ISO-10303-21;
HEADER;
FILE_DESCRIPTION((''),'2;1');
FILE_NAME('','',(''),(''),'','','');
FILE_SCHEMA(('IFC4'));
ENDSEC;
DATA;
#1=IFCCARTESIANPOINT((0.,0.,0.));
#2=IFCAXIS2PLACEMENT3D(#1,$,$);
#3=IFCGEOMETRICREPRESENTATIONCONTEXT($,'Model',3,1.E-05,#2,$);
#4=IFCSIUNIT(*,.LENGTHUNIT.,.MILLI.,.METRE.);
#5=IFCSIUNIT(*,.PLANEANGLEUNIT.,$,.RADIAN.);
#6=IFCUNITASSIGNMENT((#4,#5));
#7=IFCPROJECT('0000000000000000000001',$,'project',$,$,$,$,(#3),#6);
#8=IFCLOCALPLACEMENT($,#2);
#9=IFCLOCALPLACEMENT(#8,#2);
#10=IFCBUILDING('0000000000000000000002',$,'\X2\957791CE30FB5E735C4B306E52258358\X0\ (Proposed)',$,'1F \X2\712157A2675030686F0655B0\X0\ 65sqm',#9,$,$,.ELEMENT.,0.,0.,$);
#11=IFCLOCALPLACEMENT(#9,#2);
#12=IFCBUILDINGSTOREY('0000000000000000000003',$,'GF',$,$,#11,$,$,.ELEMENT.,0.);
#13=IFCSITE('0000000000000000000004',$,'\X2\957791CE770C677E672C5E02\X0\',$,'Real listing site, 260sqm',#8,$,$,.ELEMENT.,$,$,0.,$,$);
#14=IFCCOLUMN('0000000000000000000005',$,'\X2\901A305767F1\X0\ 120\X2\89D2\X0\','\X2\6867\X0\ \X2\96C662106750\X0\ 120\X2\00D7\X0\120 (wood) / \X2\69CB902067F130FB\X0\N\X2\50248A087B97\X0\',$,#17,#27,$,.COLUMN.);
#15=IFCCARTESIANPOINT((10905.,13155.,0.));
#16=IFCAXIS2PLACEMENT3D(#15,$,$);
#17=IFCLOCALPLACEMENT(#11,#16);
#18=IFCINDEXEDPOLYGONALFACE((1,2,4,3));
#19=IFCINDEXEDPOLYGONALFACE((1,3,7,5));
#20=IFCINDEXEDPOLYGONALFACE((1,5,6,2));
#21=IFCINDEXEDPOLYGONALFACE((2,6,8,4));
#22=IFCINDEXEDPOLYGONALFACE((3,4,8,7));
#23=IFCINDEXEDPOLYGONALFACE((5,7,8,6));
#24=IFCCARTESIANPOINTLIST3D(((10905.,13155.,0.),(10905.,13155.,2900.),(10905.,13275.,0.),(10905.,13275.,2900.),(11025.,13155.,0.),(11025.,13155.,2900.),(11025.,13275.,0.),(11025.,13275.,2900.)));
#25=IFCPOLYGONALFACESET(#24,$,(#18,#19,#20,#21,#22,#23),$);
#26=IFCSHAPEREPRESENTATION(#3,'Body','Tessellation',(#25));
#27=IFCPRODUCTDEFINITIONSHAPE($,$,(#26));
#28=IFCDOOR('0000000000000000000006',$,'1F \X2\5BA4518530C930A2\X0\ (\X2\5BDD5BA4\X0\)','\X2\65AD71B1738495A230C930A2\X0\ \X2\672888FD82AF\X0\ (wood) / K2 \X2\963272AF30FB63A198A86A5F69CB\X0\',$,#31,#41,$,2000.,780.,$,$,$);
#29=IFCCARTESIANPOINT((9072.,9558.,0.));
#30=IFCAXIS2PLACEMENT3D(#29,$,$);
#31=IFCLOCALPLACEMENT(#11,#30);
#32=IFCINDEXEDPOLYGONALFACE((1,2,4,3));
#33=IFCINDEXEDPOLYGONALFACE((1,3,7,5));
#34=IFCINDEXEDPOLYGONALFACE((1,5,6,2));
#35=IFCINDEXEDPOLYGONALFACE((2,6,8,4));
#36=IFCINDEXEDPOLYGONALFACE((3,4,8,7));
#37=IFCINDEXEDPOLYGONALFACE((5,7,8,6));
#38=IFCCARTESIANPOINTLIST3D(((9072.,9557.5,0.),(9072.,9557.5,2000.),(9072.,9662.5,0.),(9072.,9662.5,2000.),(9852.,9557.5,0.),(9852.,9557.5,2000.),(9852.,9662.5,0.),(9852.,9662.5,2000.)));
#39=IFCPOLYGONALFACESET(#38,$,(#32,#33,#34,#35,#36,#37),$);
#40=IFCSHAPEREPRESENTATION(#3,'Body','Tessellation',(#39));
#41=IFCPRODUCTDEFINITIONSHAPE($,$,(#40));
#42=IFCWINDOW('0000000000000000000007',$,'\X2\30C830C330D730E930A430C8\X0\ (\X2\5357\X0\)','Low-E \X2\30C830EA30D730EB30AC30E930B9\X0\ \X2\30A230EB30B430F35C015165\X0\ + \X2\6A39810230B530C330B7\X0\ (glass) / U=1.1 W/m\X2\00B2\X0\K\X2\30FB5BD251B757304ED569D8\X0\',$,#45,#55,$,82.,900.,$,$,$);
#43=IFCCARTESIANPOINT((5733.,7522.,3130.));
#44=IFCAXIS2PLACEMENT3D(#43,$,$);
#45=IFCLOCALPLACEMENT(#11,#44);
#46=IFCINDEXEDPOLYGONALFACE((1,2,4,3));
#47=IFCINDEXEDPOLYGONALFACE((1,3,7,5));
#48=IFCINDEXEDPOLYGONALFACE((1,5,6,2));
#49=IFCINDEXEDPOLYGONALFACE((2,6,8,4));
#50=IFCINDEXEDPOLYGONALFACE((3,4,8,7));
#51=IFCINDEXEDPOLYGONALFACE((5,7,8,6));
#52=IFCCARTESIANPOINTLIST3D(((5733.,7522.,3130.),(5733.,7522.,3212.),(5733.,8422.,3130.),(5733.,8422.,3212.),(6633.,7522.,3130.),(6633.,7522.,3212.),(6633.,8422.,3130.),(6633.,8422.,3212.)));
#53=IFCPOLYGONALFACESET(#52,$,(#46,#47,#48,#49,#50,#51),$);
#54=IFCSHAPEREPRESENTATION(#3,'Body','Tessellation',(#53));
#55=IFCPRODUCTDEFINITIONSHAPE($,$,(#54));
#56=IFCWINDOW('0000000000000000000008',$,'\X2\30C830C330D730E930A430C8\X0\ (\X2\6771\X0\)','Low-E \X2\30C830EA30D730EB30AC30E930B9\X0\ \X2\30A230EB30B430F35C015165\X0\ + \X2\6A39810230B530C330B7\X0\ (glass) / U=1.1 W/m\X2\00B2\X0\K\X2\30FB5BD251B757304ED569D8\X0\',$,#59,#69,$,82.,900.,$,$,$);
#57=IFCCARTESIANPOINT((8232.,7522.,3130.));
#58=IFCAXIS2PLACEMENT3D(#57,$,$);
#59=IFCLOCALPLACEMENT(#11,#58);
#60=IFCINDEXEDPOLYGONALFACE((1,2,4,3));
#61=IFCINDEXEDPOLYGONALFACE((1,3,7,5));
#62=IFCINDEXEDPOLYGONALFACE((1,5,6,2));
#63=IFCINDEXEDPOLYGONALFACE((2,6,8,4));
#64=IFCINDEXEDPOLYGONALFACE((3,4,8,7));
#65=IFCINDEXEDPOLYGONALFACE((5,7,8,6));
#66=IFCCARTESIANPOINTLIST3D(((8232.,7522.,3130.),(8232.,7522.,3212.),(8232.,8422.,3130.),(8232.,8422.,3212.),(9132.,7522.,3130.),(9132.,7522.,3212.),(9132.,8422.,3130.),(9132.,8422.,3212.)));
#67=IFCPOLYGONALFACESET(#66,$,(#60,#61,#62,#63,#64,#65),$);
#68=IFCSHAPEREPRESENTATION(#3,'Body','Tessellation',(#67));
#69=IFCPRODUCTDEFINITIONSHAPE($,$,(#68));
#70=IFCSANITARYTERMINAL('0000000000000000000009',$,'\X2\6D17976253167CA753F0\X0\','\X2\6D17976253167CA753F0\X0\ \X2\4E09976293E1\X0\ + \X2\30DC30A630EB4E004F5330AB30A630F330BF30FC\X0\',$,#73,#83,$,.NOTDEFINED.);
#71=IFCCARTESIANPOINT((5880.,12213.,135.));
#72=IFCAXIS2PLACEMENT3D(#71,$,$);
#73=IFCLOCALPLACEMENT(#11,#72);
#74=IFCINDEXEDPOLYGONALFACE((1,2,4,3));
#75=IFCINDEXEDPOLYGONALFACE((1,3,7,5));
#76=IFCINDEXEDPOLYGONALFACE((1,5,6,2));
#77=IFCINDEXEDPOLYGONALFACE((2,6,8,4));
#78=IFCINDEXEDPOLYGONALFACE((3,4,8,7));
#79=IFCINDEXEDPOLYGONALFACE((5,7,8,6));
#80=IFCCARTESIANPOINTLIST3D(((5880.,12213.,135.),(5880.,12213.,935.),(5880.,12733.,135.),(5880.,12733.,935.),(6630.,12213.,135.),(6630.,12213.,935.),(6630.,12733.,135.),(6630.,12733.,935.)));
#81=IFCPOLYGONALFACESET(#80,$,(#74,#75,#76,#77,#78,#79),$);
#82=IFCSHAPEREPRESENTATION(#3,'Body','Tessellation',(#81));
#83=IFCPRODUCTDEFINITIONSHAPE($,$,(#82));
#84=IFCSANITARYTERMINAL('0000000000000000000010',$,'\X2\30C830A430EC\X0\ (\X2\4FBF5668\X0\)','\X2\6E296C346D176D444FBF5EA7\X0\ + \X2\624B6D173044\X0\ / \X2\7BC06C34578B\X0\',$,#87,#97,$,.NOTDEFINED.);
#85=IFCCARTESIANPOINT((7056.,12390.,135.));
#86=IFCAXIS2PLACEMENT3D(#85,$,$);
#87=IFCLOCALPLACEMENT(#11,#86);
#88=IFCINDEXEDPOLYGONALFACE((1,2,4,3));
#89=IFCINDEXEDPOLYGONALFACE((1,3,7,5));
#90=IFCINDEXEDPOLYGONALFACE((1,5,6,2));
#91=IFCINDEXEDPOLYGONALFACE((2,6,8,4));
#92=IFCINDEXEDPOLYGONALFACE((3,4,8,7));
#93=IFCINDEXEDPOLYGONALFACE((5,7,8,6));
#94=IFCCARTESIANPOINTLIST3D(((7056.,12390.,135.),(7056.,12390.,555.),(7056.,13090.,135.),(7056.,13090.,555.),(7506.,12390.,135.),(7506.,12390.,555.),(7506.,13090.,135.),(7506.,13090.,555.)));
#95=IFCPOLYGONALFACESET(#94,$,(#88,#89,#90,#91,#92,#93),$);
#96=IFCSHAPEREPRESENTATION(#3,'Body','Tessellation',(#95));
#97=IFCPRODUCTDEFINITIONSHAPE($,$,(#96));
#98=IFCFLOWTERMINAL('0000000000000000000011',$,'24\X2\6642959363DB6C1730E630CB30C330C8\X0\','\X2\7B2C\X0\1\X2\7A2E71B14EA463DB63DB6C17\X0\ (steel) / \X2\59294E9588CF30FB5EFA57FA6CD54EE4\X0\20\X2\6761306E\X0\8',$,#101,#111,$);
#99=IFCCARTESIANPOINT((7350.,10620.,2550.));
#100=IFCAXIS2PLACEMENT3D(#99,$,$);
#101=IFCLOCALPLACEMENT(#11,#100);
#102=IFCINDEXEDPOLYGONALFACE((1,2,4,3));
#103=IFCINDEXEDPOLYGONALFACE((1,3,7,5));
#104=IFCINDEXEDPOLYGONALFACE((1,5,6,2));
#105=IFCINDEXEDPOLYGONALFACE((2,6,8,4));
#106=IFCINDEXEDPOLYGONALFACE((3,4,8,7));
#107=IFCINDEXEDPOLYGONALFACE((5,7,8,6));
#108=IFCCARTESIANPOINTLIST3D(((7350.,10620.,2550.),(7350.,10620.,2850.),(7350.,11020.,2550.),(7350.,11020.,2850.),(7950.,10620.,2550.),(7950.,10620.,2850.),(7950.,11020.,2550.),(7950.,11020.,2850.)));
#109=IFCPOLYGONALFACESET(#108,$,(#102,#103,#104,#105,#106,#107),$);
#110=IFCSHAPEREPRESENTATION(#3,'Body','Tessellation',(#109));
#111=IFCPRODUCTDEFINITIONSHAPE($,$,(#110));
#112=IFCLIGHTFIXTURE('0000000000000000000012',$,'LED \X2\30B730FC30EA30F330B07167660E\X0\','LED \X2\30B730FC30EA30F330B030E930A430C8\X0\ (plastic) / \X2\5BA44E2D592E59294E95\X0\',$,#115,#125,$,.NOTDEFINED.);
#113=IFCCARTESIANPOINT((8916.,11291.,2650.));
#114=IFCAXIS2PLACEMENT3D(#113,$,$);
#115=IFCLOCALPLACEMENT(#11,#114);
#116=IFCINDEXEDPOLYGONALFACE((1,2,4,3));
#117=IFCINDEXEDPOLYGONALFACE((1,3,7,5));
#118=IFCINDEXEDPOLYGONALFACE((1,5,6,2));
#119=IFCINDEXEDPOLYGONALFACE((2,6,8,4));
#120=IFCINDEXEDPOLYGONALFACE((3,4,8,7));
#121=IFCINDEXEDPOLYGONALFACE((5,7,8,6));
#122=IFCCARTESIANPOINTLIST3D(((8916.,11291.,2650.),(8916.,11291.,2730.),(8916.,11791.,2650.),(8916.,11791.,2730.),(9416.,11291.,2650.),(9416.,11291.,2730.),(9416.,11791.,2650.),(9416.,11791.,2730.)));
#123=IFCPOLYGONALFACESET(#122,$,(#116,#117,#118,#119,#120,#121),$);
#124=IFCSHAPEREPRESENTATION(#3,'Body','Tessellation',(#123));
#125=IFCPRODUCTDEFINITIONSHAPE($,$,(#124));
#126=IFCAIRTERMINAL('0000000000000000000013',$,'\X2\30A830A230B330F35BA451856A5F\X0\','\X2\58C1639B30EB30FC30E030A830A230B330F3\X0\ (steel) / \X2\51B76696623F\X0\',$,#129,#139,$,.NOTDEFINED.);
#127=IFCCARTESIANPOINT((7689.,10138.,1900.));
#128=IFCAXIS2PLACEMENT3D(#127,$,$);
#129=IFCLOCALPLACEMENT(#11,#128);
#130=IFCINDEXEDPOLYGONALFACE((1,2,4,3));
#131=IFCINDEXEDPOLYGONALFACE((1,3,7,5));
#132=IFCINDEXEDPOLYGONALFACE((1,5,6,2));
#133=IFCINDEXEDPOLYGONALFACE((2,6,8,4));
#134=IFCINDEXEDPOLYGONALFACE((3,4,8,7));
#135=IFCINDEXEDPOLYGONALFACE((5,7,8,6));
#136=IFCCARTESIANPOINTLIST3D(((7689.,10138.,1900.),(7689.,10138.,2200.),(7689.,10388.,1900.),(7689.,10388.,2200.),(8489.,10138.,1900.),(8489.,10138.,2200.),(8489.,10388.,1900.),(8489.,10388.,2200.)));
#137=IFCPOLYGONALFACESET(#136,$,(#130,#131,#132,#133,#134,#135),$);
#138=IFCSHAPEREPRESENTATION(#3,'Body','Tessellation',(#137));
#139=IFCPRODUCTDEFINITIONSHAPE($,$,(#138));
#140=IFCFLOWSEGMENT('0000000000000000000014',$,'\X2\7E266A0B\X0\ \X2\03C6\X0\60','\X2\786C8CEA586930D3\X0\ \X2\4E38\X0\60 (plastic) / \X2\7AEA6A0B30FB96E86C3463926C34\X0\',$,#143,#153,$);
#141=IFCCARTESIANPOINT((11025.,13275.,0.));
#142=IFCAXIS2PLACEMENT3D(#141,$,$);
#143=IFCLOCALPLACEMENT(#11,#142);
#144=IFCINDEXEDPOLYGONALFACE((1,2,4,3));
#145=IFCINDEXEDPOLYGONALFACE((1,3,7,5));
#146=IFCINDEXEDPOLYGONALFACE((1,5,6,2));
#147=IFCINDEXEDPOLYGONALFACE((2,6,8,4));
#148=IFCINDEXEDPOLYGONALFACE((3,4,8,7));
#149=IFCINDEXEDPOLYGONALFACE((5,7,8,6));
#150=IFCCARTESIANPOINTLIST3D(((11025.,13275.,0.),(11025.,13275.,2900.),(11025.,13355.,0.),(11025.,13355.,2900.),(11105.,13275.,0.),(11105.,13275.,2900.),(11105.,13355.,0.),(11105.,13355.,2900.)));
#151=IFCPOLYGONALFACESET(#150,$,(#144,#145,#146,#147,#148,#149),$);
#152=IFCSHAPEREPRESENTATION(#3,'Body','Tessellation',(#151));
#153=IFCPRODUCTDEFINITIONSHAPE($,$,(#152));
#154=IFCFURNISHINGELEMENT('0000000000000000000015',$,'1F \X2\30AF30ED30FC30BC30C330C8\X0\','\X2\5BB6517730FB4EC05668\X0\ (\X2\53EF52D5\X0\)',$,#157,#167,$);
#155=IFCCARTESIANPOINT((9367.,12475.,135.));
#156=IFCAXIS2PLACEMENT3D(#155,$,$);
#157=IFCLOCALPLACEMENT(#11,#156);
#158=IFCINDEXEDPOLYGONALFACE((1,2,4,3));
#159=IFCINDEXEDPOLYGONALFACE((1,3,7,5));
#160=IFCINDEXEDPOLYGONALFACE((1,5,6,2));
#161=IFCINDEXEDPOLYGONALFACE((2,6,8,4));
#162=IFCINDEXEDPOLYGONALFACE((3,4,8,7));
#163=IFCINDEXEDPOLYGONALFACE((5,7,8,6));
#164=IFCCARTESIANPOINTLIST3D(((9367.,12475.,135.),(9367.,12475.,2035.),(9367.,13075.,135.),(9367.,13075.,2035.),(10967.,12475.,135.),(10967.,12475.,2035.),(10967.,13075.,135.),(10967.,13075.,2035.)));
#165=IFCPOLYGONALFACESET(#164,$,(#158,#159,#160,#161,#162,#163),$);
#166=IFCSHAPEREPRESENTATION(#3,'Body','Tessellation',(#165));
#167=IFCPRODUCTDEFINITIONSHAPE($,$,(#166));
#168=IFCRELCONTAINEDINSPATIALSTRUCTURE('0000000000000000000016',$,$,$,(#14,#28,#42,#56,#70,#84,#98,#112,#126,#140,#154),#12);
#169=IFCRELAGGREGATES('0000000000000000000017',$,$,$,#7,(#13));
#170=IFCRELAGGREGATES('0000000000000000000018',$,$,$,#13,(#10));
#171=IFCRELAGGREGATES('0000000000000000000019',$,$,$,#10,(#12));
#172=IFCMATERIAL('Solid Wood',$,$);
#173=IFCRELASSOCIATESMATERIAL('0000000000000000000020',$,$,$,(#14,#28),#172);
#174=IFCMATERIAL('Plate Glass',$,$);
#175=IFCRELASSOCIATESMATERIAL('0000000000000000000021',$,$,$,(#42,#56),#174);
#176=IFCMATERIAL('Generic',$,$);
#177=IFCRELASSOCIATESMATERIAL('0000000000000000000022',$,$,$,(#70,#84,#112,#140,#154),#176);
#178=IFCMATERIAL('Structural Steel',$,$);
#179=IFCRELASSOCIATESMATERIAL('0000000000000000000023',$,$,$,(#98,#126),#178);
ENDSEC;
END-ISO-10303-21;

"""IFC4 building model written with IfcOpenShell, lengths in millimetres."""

from ifc_helpers import new_model, si_unit, frame, frame_2d, origin, place, context, project, spatial, rectangle, extrude, material, element, save


model = new_model("IFC4")

# Units and contexts
model_context = context("Model", 3, precision=1e-05, world=origin())
ifc_project = project(units=[si_unit("LENGTHUNIT", "METRE", prefix="MILLI"), si_unit("PLANEANGLEUNIT", "RADIAN")], contexts=[model_context])

# Site, building, storey
site_placement = place(None, origin())
site = spatial("IfcSite", under=ifc_project, at=site_placement, Name="長野県松本市", ObjectType="Real listing site, 260sqm", CompositionType="ELEMENT", RefElevation=0.0)
building_placement = place(site_placement, origin())
building = spatial("IfcBuilding", under=site, at=building_placement, Name="長野・平屋の別荘 (Proposed)", ObjectType="1F 無垢材と漆喰 65sqm", CompositionType="ELEMENT", ElevationOfRefHeight=0.0, ElevationOfTerrain=0.0)
storey_placement = place(building_placement, origin())
storey = spatial("IfcBuildingStorey", under=building, at=storey_placement, Name="GF", CompositionType="ELEMENT", Elevation=0.0)

# Column
ifc_material_1 = material(Name="Solid Wood")
column_1_placement = place(storey_placement, frame((10905.0, 13155.0, 0.0)))
element("IfcColumn", 1, at=column_1_placement, inside=storey, material=ifc_material_1, Name="通し柱 120角", Description="桧 集成材 120×120 (wood) / 構造柱・N値計算", PredefinedType="COLUMN", context=model_context, shape_type="SweptSolid", body=[
    extrude(rectangle(XDim=120.0, YDim=120.0, at=frame_2d((60.0, 60.0))), frame((10905.0, 13155.0, 0.0)), (0.0, 0.0, 1.0), 2900.0),
])

# Door
door_placement = place(storey_placement, frame((9072.0, 9558.0, 0.0)))
element("IfcDoor", 2, at=door_placement, inside=storey, material=ifc_material_1, Name="1F 室内ドア (寝室)", Description="断熱玄関ドア 木製芯 (wood) / K2 防犯・採風機構", OverallHeight=2000.0, OverallWidth=780.0, context=model_context, shape_type="SweptSolid", body=[
    extrude(rectangle(XDim=780.0, YDim=105.0, at=frame_2d((390.0, 52.0))), frame((9072.0, 9558.0, 0.0)), (0.0, 0.0, 1.0), 2000.0),
])

# Windows
ifc_material_2 = material(Name="Plate Glass")
window_1_placement = place(storey_placement, frame((5733.0, 7522.0, 3130.0)))
element("IfcWindow", 3, at=window_1_placement, inside=storey, material=ifc_material_2, Name="トップライト (南)", Description="Low-E トリプルガラス アルゴン封入 + 樹脂サッシ (glass) / U=1.1 W/m²K・寒冷地仕様", OverallHeight=82.0, OverallWidth=900.0, context=model_context, shape_type="SweptSolid", body=[
    extrude(rectangle(XDim=900.0, YDim=900.0, at=frame_2d((450.0, 450.0))), frame((5733.0, 7522.0, 3130.0)), (0.0, 0.0, 1.0), 82.0),
])
window_2_placement = place(storey_placement, frame((8232.0, 7522.0, 3130.0)))
element("IfcWindow", 4, at=window_2_placement, inside=storey, material=ifc_material_2, Name="トップライト (東)", Description="Low-E トリプルガラス アルゴン封入 + 樹脂サッシ (glass) / U=1.1 W/m²K・寒冷地仕様", OverallHeight=82.0, OverallWidth=900.0, context=model_context, shape_type="SweptSolid", body=[
    extrude(rectangle(XDim=900.0, YDim=900.0, at=frame_2d((450.0, 450.0))), frame((8232.0, 7522.0, 3130.0)), (0.0, 0.0, 1.0), 82.0),
])

# Sanitary terminals
ifc_material_3 = material(Name="Generic")
sanitary_terminal_1_placement = place(storey_placement, frame((5880.0, 12213.0, 135.0)))
element("IfcSanitaryTerminal", 5, at=sanitary_terminal_1_placement, inside=storey, material=ifc_material_3, Name="洗面化粧台", Description="洗面化粧台 三面鏡 + ボウル一体カウンター", PredefinedType="NOTDEFINED", context=model_context, shape_type="SweptSolid", body=[
    extrude(rectangle(XDim=750.0, YDim=520.0, at=frame_2d((375.0, 260.0))), frame((5880.0, 12213.0, 135.0)), (0.0, 0.0, 1.0), 800.0),
])
sanitary_terminal_2_placement = place(storey_placement, frame((7056.0, 12390.0, 135.0)))
element("IfcSanitaryTerminal", 6, at=sanitary_terminal_2_placement, inside=storey, material=ifc_material_3, Name="トイレ (便器)", Description="温水洗浄便座 + 手洗い / 節水型", PredefinedType="NOTDEFINED", context=model_context, shape_type="SweptSolid", body=[
    extrude(rectangle(XDim=450.0, YDim=700.0, at=frame_2d((225.0, 350.0))), frame((7056.0, 12390.0, 135.0)), (0.0, 0.0, 1.0), 420.0),
])

# Flow terminal
ifc_material_4 = material(Name="Structural Steel")
flow_terminal_placement = place(storey_placement, frame((7350.0, 10620.0, 2550.0)))
element("IfcFlowTerminal", 7, at=flow_terminal_placement, inside=storey, material=ifc_material_4, Name="24時間換気ユニット", Description="第1種熱交換換気 (steel) / 天井裏・建基法令20条の8", context=model_context, shape_type="SweptSolid", body=[
    extrude(rectangle(XDim=600.0, YDim=400.0, at=frame_2d((300.0, 200.0))), frame((7350.0, 10620.0, 2550.0)), (0.0, 0.0, 1.0), 300.0),
])

# Light fixture
light_fixture_placement = place(storey_placement, frame((8916.0, 11291.0, 2650.0)))
element("IfcLightFixture", 8, at=light_fixture_placement, inside=storey, material=ifc_material_3, Name="LED シーリング照明", Description="LED シーリングライト (plastic) / 室中央天井", PredefinedType="NOTDEFINED", context=model_context, shape_type="SweptSolid", body=[
    extrude(rectangle(XDim=500.0, YDim=500.0, at=frame_2d((250.0, 250.0))), frame((8916.0, 11291.0, 2650.0)), (0.0, 0.0, 1.0), 80.0),
])

# Air terminal
air_terminal_placement = place(storey_placement, frame((7689.0, 10138.0, 1900.0)))
element("IfcAirTerminal", 9, at=air_terminal_placement, inside=storey, material=ifc_material_4, Name="エアコン室内機", Description="壁掛ルームエアコン (steel) / 冷暖房", PredefinedType="NOTDEFINED", context=model_context, shape_type="SweptSolid", body=[
    extrude(rectangle(XDim=800.0, YDim=250.0, at=frame_2d((400.0, 125.0))), frame((7689.0, 10138.0, 1900.0)), (0.0, 0.0, 1.0), 300.0),
])

# Flow segment
flow_segment_placement = place(storey_placement, frame((11025.0, 13275.0, 0.0)))
element("IfcFlowSegment", 10, at=flow_segment_placement, inside=storey, material=ifc_material_3, Name="縦樋 φ60", Description="硬質塩ビ 丸60 (plastic) / 竪樋・雨水排水", context=model_context, shape_type="SweptSolid", body=[
    extrude(rectangle(XDim=80.0, YDim=80.0, at=frame_2d((40.0, 40.0))), frame((11025.0, 13275.0, 0.0)), (0.0, 0.0, 1.0), 2900.0),
])

# Furnishing element
furnishing_placement = place(storey_placement, frame((9367.0, 12475.0, 135.0)))
element("IfcFurnishingElement", 11, at=furnishing_placement, inside=storey, material=ifc_material_3, Name="1F クローゼット", Description="家具・什器 (可動)", context=model_context, shape_type="SweptSolid", body=[
    extrude(rectangle(XDim=1600.0, YDim=600.0, at=frame_2d((800.0, 300.0))), frame((9367.0, 12475.0, 135.0)), (0.0, 0.0, 1.0), 1900.0),
])

save(model, "model.ifc")
